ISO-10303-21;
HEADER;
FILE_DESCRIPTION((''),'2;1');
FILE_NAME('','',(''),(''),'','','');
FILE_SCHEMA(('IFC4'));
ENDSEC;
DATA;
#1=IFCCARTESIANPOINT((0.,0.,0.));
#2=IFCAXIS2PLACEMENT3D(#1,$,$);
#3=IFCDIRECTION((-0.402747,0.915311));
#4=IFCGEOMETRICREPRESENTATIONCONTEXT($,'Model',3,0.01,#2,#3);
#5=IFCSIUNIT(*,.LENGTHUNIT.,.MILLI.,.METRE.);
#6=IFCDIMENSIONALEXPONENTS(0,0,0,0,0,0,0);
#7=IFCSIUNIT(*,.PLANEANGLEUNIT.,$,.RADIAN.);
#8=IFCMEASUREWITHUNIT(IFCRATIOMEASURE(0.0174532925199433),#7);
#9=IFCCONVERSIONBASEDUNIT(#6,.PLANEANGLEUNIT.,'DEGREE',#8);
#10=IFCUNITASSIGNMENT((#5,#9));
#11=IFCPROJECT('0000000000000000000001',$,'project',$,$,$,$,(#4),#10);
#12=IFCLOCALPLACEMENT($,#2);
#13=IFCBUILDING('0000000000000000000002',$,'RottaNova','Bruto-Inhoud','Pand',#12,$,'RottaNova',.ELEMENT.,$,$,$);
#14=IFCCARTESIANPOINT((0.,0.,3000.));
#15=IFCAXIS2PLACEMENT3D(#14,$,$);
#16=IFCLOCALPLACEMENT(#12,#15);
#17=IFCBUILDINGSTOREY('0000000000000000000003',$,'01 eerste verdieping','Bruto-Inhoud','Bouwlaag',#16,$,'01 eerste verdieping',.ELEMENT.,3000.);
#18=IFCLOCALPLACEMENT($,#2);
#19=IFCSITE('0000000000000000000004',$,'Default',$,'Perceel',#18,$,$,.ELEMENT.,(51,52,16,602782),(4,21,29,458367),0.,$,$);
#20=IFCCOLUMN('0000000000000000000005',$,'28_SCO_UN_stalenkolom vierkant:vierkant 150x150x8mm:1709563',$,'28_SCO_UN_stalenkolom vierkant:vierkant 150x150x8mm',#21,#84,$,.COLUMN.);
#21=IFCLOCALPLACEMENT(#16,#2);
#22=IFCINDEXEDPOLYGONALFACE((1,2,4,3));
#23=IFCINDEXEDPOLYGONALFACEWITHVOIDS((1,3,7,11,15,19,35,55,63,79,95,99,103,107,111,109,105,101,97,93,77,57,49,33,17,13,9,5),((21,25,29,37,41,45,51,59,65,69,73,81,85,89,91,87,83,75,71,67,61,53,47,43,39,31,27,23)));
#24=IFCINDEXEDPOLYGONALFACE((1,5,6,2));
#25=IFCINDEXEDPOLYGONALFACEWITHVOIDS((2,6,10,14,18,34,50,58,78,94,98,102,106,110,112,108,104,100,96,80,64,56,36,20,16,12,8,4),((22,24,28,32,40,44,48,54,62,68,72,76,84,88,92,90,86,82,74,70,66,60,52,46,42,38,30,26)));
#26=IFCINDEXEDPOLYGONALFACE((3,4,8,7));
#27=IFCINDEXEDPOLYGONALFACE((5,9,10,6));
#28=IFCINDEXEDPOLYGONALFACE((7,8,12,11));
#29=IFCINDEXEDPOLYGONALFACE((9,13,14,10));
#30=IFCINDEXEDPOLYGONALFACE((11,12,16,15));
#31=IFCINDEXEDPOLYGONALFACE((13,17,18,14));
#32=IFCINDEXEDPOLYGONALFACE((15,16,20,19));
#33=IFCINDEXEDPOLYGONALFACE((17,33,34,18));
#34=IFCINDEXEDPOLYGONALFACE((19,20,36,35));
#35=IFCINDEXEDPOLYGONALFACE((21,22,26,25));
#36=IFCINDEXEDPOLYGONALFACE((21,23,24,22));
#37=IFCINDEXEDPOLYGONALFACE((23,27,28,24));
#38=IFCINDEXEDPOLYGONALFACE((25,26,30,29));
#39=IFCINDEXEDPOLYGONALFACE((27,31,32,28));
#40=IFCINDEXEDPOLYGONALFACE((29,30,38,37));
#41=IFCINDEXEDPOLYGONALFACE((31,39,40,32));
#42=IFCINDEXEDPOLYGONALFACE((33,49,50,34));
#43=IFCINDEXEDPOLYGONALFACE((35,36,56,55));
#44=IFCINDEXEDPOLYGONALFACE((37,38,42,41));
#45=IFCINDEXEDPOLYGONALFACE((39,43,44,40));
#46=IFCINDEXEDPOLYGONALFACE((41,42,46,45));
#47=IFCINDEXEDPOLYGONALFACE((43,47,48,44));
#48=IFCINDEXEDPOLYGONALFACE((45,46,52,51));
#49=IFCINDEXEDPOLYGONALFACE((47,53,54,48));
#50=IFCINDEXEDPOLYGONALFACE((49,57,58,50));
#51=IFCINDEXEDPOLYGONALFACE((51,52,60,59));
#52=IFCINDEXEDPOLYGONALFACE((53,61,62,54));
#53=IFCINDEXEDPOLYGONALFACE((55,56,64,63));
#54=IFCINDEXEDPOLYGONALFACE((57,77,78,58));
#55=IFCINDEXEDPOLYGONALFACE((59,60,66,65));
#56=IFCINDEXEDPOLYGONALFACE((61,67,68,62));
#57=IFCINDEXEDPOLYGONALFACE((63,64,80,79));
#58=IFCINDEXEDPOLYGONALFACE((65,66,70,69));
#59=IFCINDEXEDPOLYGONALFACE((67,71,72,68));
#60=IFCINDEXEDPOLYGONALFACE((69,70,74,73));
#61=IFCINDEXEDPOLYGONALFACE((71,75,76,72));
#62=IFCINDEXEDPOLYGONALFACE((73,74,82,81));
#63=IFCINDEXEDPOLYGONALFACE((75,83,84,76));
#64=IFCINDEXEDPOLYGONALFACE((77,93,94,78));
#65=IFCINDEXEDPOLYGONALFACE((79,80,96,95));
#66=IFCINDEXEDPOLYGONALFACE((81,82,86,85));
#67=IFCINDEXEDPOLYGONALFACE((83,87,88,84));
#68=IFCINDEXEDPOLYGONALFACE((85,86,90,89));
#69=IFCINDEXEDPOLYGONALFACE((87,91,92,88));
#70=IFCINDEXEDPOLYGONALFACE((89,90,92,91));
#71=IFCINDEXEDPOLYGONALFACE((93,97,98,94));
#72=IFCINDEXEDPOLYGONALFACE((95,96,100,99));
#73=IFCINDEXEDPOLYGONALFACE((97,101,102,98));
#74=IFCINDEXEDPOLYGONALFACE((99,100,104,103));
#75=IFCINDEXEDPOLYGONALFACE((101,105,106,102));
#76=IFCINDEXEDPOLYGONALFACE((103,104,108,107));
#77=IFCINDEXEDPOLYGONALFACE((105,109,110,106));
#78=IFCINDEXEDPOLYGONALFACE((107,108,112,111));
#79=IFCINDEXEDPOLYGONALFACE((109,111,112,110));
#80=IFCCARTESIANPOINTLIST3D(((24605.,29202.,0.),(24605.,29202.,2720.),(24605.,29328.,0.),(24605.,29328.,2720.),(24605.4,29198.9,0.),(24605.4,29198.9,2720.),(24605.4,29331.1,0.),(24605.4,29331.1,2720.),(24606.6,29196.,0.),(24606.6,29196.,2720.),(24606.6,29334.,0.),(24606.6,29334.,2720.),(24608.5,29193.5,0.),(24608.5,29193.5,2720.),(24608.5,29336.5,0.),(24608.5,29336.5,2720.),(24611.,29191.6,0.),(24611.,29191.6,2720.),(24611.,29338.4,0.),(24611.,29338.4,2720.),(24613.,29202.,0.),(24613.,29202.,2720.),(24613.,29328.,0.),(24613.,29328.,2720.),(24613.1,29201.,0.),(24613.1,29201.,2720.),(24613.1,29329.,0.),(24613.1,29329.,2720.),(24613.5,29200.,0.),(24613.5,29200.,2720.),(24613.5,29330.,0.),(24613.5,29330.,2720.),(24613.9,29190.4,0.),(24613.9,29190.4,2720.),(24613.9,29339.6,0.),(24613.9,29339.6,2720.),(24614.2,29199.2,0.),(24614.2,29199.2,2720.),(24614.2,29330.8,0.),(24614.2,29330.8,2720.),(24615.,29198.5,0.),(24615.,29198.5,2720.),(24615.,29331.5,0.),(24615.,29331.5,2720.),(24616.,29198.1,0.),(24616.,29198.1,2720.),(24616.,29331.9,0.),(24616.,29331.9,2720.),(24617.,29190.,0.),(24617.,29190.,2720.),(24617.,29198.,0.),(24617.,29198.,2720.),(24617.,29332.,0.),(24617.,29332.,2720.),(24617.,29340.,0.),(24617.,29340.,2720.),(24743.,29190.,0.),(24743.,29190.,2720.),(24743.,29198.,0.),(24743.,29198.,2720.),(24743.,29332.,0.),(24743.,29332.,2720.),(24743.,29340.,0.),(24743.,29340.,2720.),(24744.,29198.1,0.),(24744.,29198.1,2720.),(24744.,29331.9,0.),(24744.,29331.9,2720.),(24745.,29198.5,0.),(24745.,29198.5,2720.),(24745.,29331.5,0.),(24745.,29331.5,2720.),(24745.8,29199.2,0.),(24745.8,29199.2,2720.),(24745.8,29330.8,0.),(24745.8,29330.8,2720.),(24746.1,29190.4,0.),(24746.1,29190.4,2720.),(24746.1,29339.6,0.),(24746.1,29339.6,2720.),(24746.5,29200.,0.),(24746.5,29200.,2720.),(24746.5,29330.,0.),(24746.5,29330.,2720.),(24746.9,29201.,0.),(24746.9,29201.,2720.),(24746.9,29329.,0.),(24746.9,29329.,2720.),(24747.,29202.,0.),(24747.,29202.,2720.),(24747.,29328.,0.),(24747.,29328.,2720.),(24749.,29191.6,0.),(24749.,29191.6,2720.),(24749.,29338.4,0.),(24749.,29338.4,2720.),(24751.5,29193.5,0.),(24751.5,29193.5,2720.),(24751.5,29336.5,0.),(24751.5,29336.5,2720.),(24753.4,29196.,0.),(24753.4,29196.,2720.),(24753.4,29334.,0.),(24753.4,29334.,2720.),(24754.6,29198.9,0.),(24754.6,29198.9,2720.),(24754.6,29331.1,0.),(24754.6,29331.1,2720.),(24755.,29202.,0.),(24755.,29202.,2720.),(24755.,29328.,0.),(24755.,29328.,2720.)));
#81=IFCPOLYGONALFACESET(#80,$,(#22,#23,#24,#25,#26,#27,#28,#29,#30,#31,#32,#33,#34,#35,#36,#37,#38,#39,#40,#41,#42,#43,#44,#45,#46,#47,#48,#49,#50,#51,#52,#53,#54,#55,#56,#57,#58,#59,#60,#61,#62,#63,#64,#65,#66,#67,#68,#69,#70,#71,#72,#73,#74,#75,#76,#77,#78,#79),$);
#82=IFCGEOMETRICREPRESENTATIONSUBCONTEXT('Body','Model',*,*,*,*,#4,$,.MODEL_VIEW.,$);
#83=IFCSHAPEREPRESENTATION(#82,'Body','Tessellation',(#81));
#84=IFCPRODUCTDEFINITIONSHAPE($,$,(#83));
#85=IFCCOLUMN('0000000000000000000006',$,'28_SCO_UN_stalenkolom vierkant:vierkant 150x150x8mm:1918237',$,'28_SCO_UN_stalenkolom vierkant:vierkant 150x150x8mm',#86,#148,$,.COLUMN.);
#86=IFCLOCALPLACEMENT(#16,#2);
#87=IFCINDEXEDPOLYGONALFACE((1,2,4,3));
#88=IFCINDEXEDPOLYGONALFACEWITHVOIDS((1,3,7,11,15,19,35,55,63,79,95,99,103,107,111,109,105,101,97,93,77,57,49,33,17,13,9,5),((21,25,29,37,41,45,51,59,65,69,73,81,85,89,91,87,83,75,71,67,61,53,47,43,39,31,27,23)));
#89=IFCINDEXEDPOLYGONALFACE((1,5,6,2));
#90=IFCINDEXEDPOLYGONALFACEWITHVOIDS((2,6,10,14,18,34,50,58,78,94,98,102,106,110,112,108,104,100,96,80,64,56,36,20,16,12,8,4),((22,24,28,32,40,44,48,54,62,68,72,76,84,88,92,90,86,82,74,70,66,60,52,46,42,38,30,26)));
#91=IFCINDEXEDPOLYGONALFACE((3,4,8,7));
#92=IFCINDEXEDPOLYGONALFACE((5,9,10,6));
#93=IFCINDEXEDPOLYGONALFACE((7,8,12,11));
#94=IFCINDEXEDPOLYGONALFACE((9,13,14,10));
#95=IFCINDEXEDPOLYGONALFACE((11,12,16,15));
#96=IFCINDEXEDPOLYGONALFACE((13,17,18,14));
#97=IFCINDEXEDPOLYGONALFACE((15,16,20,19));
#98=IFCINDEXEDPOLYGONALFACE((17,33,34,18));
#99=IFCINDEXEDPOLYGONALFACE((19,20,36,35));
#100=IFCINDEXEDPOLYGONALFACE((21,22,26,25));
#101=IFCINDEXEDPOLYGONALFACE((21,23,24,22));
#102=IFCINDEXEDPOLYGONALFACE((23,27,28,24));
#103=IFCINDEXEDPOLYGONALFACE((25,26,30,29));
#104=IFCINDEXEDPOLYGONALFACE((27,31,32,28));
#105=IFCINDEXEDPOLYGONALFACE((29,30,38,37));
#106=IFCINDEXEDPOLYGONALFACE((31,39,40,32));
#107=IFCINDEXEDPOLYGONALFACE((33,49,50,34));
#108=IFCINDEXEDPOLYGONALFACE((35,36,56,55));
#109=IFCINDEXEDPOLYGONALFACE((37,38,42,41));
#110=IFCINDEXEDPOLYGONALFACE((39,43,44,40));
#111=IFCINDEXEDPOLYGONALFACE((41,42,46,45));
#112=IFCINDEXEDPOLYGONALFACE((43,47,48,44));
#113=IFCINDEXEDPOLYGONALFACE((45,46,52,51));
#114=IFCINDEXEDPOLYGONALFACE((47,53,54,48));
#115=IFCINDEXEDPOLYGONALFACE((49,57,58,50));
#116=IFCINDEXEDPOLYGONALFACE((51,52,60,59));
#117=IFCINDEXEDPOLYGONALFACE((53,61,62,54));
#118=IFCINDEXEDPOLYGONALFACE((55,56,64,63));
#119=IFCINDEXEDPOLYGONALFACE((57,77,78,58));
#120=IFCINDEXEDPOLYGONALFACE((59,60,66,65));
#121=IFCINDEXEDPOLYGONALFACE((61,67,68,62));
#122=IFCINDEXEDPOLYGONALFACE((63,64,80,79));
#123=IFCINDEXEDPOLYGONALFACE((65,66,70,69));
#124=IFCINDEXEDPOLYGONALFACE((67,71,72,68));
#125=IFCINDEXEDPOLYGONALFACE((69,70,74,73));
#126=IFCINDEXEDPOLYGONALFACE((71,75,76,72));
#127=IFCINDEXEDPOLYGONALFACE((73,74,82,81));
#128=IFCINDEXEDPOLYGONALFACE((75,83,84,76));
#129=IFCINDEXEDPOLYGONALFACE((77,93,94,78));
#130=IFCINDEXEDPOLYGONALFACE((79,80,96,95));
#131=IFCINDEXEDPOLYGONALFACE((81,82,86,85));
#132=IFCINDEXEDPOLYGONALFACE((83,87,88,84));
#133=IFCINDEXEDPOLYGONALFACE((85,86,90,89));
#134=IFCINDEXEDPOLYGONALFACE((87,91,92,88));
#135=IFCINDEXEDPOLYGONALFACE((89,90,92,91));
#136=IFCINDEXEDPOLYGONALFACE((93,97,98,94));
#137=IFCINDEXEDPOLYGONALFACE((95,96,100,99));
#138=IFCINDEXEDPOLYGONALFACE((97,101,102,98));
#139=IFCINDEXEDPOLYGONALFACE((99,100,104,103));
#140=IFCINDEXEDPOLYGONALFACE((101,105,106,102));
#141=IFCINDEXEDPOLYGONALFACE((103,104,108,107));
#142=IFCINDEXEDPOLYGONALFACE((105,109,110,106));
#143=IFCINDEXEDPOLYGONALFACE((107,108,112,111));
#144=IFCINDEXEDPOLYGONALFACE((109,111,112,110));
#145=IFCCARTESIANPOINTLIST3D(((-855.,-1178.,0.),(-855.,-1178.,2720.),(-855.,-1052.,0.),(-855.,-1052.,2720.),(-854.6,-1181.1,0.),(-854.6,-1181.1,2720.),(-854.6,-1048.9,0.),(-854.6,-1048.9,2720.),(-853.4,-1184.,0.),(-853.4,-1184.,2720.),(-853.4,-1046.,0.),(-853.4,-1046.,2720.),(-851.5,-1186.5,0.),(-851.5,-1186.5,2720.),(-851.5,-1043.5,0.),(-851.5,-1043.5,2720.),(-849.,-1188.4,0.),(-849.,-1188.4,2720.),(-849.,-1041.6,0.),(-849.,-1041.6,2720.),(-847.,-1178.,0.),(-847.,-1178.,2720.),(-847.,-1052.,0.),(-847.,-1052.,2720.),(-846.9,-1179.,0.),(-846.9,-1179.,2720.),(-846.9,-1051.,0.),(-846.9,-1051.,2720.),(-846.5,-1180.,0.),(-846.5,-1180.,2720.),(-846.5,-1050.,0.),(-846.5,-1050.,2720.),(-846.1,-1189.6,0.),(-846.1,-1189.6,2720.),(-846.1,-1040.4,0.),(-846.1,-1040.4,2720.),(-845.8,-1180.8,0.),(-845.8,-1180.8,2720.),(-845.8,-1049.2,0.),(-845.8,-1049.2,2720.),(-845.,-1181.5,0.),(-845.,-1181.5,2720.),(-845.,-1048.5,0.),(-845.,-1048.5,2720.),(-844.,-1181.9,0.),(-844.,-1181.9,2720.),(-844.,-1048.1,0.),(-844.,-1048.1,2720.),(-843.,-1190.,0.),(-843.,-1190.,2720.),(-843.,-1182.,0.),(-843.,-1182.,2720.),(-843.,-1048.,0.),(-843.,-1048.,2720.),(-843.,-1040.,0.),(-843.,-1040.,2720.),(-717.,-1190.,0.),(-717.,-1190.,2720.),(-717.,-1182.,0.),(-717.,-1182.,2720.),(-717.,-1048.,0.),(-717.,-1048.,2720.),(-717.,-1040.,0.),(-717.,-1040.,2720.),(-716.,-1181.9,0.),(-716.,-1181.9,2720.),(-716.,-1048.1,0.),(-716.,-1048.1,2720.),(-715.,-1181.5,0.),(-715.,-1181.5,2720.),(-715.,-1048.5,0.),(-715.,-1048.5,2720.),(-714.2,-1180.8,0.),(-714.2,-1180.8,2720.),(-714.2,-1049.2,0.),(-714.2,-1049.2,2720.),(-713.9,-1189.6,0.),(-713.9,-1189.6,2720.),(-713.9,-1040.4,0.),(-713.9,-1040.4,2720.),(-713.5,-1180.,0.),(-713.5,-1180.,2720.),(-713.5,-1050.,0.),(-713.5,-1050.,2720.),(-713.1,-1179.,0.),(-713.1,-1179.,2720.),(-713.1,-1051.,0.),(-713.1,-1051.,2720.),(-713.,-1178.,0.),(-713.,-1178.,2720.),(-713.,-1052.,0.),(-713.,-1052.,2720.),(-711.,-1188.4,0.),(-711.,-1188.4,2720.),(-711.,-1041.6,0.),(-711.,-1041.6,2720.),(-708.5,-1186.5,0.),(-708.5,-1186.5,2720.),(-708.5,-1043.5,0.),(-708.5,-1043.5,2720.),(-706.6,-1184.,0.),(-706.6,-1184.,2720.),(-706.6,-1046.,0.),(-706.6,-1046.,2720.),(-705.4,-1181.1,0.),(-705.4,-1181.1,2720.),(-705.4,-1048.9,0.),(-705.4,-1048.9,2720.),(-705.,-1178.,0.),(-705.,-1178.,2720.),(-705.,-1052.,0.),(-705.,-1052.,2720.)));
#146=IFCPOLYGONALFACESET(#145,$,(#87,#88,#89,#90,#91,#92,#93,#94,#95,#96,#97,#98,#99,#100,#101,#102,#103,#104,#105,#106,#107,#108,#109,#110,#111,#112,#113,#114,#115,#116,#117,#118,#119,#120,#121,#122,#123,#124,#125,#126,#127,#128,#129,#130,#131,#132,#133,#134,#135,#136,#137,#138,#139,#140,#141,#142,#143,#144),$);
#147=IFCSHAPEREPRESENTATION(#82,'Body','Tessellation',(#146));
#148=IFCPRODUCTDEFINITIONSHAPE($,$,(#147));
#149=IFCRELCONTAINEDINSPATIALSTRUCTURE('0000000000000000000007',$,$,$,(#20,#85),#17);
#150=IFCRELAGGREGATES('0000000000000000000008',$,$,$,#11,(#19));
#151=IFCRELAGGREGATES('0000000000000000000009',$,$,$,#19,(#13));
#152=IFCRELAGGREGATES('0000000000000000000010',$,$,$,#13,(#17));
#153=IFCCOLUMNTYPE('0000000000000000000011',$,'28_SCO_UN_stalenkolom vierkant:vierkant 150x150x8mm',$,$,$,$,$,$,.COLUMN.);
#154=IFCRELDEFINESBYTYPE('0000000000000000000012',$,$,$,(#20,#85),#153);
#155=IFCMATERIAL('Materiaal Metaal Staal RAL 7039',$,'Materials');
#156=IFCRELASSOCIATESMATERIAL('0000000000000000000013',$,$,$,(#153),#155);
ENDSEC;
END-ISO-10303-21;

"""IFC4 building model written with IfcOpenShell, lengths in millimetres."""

from ifc_helpers import new_model, entity, si_unit, converted_unit, direction, frame, frame_2d, origin, place, context, subcontext, project, spatial, polyline, circle_curve, parameter, trimmed, segment, composite_curve, outline, extrude, source, transform, mapped, material, material_profile, profile_set, type_object, type_shapes, element, save


model = new_model("IFC4")

# Units and contexts
model_context = context("Model", 3, precision=0.01, world=origin(), true_north=direction((-0.402747, 0.915311)))
body_context = subcontext(model_context, "Body", "Model", "MODEL_VIEW")
ifc_project = project(units=[si_unit("LENGTHUNIT", "METRE", prefix="MILLI"), converted_unit("PLANEANGLEUNIT", "DEGREE", entity("IfcRatioMeasure", 0.0174532925199433), si_unit("PLANEANGLEUNIT", "RADIAN"), dimensions=[0, 0, 0, 0, 0, 0, 0])], contexts=[model_context])

# Site, building, storey
site_placement = place(None, origin())
site = spatial("IfcSite", under=ifc_project, at=site_placement, Name="Default", ObjectType="Perceel", CompositionType="ELEMENT", RefLatitude=(51, 52, 16, 602782), RefLongitude=(4, 21, 29, 458367), RefElevation=0.0)
building_placement = place(None, origin())
building = spatial("IfcBuilding", under=site, at=building_placement, Name="RottaNova", Description="Bruto-Inhoud", ObjectType="Pand", LongName="RottaNova", CompositionType="ELEMENT")
storey_placement = place(building_placement, frame((0.0, 0.0, 3000.0)))
storey = spatial("IfcBuildingStorey", under=building, at=storey_placement, Name="01 eerste verdieping", Description="Bruto-Inhoud", ObjectType="Bouwlaag", LongName="01 eerste verdieping", CompositionType="ELEMENT", Elevation=3000.0)

# Columns
ifc_material_1 = material(Name="Materiaal Metaal Staal RAL 7039", Category="Materials")
ifc_material_profile = material_profile(ifc_material_1, outline(composite_curve([segment(trimmed(circle_curve(frame_2d((63.0, -63.0), x_axis=(1.0, 0.0)), 12.0), [parameter(270.0)], [parameter(360.0)], True, "PARAMETER"), True, "CONTINUOUS"), segment(polyline([(75.0, -63.0), (75.0, 63.0)]), True, "CONTINUOUS"), segment(trimmed(circle_curve(frame_2d((63.0, 63.0), x_axis=(1.0, 0.0)), 12.0), [parameter(360.0)], [parameter(90.0)], True, "PARAMETER"), True, "CONTINUOUS"), segment(polyline([(63.0, 75.0), (-63.0, 75.0)]), True, "CONTINUOUS"), segment(trimmed(circle_curve(frame_2d((-63.0, 63.0), x_axis=(1.0, 0.0)), 12.0), [parameter(90.0)], [parameter(180.0)], True, "PARAMETER"), True, "CONTINUOUS"), segment(polyline([(-75.0, 63.0), (-75.0, -63.0)]), True, "CONTINUOUS"), segment(trimmed(circle_curve(frame_2d((-63.0, -63.0), x_axis=(1.0, 0.0)), 12.0), [parameter(180.0)], [parameter(270.0)], True, "PARAMETER"), True, "CONTINUOUS"), segment(polyline([(-63.0, -75.0), (63.0, -75.0)]), True, "CONTINUOUS")], self_intersect=False), holes=[composite_curve([segment(polyline([(-67.0, -63.0), (-67.0, 63.0)]), True, "CONTINUOUS"), segment(trimmed(circle_curve(frame_2d((-63.0, 63.0), x_axis=(1.0, 0.0)), 4.0), [parameter(90.0)], [parameter(180.0)], True, "PARAMETER"), False, "CONTINUOUS"), segment(polyline([(-63.0, 67.0), (63.0, 67.0)]), True, "CONTINUOUS"), segment(trimmed(circle_curve(frame_2d((63.0, 63.0), x_axis=(1.0, 0.0)), 4.0), [parameter(0.0)], [parameter(90.0)], True, "PARAMETER"), False, "CONTINUOUS"), segment(polyline([(67.0, 63.0), (67.0, -63.0)]), True, "CONTINUOUS"), segment(trimmed(circle_curve(frame_2d((63.0, -63.0), x_axis=(1.0, 0.0)), 4.0), [parameter(270.0)], [parameter(0.0)], True, "PARAMETER"), False, "CONTINUOUS"), segment(polyline([(63.0, -67.0), (-63.0, -67.0)]), True, "CONTINUOUS"), segment(trimmed(circle_curve(frame_2d((-63.0, -63.0), x_axis=(1.0, 0.0)), 4.0), [parameter(180.0)], [parameter(270.0)], True, "PARAMETER"), False, "CONTINUOUS")], self_intersect=False)]), Name="vierkant 150x150x8mm")
ifc_profile_set = profile_set([ifc_material_profile], Name="vierkant 150x150x8mm")
column_type_1 = type_object("IfcColumnType", Name="28_SCO_UN_stalenkolom vierkant:vierkant 150x150x8mm", PredefinedType="COLUMN", material=ifc_profile_set)
shared_shape_1 = source(origin(), body_context, "Body", "SweptSolid", [
    extrude(outline(composite_curve([segment(polyline([(-63.0, -75.0), (63.0, -75.0)]), True, "CONTINUOUS"), segment(trimmed(circle_curve(frame_2d((63.0, -63.0), x_axis=(-1.0, 0.0)), 12.0), [parameter(90.0)], [parameter(180.0)], True, "PARAMETER"), True, "CONTINUOUS"), segment(polyline([(75.0, -63.0), (75.0, 63.0)]), True, "CONTINUOUS"), segment(trimmed(circle_curve(frame_2d((63.0, 63.0), x_axis=(-1.0, 0.0)), 12.0), [parameter(180.0)], [parameter(270.0)], True, "PARAMETER"), True, "CONTINUOUS"), segment(polyline([(63.0, 75.0), (-63.0, 75.0)]), True, "CONTINUOUS"), segment(trimmed(circle_curve(frame_2d((-63.0, 63.0), x_axis=(-1.0, 0.0)), 12.0), [parameter(270.0)], [parameter(0.0)], True, "PARAMETER"), True, "CONTINUOUS"), segment(polyline([(-75.0, 63.0), (-75.0, -63.0)]), True, "CONTINUOUS"), segment(trimmed(circle_curve(frame_2d((-63.0, -63.0), x_axis=(-1.0, 0.0)), 12.0), [parameter(0.0)], [parameter(90.0)], True, "PARAMETER"), True, "CONTINUOUS")], self_intersect=False), holes=[composite_curve([segment(trimmed(circle_curve(frame_2d((63.0, -63.0), x_axis=(-1.0, 0.0)), 4.0), [parameter(90.0)], [parameter(180.0)], True, "PARAMETER"), False, "CONTINUOUS"), segment(polyline([(63.0, -67.0), (-63.0, -67.0)]), True, "CONTINUOUS"), segment(trimmed(circle_curve(frame_2d((-63.0, -63.0), x_axis=(-1.0, 0.0)), 4.0), [parameter(0.0)], [parameter(90.0)], True, "PARAMETER"), False, "CONTINUOUS"), segment(polyline([(-67.0, -63.0), (-67.0, 63.0)]), True, "CONTINUOUS"), segment(trimmed(circle_curve(frame_2d((-63.0, 63.0), x_axis=(-1.0, 0.0)), 4.0), [parameter(270.0)], [parameter(360.0)], True, "PARAMETER"), False, "CONTINUOUS"), segment(polyline([(-63.0, 67.0), (63.0, 67.0)]), True, "CONTINUOUS"), segment(trimmed(circle_curve(frame_2d((63.0, 63.0), x_axis=(-1.0, 0.0)), 4.0), [parameter(180.0)], [parameter(270.0)], True, "PARAMETER"), False, "CONTINUOUS"), segment(polyline([(67.0, 63.0), (67.0, -63.0)]), True, "CONTINUOUS")], self_intersect=False)]), frame((76.6, 76.6, 0.0), z_axis=(0.0, 0.0, 1.0), x_axis=(-1.0, 0.0, 0.0)), (0.0, 0.0, 1.0), 2720.0),
])
type_shapes(column_type_1, [shared_shape_1])
column_1_placement = place(storey_placement, frame((24603.4, 29188.4, 0.0)))
element("IfcColumn", 1, at=column_1_placement, inside=storey, type_object=column_type_1, Name="28_SCO_UN_stalenkolom vierkant:vierkant 150x150x8mm:1709563", ObjectType="28_SCO_UN_stalenkolom vierkant:vierkant 150x150x8mm", PredefinedType="COLUMN", context=body_context, shape_type="MappedRepresentation", body=[
    mapped(shared_shape_1, transform((0.0, 0.0, 0.0), scale=1.0)),
])
column_2_placement = place(storey_placement, frame((-703.4, -1038.4, 0.0), z_axis=(0.0, 0.0, 1.0), x_axis=(-1.0, 0.0, 0.0)))
element("IfcColumn", 2, at=column_2_placement, inside=storey, type_object=column_type_1, Name="28_SCO_UN_stalenkolom vierkant:vierkant 150x150x8mm:1918237", ObjectType="28_SCO_UN_stalenkolom vierkant:vierkant 150x150x8mm", PredefinedType="COLUMN", context=body_context, shape_type="MappedRepresentation", body=[
    mapped(shared_shape_1, transform((0.0, 0.0, 0.0), scale=1.0)),
])

save(model, "model.ifc")
